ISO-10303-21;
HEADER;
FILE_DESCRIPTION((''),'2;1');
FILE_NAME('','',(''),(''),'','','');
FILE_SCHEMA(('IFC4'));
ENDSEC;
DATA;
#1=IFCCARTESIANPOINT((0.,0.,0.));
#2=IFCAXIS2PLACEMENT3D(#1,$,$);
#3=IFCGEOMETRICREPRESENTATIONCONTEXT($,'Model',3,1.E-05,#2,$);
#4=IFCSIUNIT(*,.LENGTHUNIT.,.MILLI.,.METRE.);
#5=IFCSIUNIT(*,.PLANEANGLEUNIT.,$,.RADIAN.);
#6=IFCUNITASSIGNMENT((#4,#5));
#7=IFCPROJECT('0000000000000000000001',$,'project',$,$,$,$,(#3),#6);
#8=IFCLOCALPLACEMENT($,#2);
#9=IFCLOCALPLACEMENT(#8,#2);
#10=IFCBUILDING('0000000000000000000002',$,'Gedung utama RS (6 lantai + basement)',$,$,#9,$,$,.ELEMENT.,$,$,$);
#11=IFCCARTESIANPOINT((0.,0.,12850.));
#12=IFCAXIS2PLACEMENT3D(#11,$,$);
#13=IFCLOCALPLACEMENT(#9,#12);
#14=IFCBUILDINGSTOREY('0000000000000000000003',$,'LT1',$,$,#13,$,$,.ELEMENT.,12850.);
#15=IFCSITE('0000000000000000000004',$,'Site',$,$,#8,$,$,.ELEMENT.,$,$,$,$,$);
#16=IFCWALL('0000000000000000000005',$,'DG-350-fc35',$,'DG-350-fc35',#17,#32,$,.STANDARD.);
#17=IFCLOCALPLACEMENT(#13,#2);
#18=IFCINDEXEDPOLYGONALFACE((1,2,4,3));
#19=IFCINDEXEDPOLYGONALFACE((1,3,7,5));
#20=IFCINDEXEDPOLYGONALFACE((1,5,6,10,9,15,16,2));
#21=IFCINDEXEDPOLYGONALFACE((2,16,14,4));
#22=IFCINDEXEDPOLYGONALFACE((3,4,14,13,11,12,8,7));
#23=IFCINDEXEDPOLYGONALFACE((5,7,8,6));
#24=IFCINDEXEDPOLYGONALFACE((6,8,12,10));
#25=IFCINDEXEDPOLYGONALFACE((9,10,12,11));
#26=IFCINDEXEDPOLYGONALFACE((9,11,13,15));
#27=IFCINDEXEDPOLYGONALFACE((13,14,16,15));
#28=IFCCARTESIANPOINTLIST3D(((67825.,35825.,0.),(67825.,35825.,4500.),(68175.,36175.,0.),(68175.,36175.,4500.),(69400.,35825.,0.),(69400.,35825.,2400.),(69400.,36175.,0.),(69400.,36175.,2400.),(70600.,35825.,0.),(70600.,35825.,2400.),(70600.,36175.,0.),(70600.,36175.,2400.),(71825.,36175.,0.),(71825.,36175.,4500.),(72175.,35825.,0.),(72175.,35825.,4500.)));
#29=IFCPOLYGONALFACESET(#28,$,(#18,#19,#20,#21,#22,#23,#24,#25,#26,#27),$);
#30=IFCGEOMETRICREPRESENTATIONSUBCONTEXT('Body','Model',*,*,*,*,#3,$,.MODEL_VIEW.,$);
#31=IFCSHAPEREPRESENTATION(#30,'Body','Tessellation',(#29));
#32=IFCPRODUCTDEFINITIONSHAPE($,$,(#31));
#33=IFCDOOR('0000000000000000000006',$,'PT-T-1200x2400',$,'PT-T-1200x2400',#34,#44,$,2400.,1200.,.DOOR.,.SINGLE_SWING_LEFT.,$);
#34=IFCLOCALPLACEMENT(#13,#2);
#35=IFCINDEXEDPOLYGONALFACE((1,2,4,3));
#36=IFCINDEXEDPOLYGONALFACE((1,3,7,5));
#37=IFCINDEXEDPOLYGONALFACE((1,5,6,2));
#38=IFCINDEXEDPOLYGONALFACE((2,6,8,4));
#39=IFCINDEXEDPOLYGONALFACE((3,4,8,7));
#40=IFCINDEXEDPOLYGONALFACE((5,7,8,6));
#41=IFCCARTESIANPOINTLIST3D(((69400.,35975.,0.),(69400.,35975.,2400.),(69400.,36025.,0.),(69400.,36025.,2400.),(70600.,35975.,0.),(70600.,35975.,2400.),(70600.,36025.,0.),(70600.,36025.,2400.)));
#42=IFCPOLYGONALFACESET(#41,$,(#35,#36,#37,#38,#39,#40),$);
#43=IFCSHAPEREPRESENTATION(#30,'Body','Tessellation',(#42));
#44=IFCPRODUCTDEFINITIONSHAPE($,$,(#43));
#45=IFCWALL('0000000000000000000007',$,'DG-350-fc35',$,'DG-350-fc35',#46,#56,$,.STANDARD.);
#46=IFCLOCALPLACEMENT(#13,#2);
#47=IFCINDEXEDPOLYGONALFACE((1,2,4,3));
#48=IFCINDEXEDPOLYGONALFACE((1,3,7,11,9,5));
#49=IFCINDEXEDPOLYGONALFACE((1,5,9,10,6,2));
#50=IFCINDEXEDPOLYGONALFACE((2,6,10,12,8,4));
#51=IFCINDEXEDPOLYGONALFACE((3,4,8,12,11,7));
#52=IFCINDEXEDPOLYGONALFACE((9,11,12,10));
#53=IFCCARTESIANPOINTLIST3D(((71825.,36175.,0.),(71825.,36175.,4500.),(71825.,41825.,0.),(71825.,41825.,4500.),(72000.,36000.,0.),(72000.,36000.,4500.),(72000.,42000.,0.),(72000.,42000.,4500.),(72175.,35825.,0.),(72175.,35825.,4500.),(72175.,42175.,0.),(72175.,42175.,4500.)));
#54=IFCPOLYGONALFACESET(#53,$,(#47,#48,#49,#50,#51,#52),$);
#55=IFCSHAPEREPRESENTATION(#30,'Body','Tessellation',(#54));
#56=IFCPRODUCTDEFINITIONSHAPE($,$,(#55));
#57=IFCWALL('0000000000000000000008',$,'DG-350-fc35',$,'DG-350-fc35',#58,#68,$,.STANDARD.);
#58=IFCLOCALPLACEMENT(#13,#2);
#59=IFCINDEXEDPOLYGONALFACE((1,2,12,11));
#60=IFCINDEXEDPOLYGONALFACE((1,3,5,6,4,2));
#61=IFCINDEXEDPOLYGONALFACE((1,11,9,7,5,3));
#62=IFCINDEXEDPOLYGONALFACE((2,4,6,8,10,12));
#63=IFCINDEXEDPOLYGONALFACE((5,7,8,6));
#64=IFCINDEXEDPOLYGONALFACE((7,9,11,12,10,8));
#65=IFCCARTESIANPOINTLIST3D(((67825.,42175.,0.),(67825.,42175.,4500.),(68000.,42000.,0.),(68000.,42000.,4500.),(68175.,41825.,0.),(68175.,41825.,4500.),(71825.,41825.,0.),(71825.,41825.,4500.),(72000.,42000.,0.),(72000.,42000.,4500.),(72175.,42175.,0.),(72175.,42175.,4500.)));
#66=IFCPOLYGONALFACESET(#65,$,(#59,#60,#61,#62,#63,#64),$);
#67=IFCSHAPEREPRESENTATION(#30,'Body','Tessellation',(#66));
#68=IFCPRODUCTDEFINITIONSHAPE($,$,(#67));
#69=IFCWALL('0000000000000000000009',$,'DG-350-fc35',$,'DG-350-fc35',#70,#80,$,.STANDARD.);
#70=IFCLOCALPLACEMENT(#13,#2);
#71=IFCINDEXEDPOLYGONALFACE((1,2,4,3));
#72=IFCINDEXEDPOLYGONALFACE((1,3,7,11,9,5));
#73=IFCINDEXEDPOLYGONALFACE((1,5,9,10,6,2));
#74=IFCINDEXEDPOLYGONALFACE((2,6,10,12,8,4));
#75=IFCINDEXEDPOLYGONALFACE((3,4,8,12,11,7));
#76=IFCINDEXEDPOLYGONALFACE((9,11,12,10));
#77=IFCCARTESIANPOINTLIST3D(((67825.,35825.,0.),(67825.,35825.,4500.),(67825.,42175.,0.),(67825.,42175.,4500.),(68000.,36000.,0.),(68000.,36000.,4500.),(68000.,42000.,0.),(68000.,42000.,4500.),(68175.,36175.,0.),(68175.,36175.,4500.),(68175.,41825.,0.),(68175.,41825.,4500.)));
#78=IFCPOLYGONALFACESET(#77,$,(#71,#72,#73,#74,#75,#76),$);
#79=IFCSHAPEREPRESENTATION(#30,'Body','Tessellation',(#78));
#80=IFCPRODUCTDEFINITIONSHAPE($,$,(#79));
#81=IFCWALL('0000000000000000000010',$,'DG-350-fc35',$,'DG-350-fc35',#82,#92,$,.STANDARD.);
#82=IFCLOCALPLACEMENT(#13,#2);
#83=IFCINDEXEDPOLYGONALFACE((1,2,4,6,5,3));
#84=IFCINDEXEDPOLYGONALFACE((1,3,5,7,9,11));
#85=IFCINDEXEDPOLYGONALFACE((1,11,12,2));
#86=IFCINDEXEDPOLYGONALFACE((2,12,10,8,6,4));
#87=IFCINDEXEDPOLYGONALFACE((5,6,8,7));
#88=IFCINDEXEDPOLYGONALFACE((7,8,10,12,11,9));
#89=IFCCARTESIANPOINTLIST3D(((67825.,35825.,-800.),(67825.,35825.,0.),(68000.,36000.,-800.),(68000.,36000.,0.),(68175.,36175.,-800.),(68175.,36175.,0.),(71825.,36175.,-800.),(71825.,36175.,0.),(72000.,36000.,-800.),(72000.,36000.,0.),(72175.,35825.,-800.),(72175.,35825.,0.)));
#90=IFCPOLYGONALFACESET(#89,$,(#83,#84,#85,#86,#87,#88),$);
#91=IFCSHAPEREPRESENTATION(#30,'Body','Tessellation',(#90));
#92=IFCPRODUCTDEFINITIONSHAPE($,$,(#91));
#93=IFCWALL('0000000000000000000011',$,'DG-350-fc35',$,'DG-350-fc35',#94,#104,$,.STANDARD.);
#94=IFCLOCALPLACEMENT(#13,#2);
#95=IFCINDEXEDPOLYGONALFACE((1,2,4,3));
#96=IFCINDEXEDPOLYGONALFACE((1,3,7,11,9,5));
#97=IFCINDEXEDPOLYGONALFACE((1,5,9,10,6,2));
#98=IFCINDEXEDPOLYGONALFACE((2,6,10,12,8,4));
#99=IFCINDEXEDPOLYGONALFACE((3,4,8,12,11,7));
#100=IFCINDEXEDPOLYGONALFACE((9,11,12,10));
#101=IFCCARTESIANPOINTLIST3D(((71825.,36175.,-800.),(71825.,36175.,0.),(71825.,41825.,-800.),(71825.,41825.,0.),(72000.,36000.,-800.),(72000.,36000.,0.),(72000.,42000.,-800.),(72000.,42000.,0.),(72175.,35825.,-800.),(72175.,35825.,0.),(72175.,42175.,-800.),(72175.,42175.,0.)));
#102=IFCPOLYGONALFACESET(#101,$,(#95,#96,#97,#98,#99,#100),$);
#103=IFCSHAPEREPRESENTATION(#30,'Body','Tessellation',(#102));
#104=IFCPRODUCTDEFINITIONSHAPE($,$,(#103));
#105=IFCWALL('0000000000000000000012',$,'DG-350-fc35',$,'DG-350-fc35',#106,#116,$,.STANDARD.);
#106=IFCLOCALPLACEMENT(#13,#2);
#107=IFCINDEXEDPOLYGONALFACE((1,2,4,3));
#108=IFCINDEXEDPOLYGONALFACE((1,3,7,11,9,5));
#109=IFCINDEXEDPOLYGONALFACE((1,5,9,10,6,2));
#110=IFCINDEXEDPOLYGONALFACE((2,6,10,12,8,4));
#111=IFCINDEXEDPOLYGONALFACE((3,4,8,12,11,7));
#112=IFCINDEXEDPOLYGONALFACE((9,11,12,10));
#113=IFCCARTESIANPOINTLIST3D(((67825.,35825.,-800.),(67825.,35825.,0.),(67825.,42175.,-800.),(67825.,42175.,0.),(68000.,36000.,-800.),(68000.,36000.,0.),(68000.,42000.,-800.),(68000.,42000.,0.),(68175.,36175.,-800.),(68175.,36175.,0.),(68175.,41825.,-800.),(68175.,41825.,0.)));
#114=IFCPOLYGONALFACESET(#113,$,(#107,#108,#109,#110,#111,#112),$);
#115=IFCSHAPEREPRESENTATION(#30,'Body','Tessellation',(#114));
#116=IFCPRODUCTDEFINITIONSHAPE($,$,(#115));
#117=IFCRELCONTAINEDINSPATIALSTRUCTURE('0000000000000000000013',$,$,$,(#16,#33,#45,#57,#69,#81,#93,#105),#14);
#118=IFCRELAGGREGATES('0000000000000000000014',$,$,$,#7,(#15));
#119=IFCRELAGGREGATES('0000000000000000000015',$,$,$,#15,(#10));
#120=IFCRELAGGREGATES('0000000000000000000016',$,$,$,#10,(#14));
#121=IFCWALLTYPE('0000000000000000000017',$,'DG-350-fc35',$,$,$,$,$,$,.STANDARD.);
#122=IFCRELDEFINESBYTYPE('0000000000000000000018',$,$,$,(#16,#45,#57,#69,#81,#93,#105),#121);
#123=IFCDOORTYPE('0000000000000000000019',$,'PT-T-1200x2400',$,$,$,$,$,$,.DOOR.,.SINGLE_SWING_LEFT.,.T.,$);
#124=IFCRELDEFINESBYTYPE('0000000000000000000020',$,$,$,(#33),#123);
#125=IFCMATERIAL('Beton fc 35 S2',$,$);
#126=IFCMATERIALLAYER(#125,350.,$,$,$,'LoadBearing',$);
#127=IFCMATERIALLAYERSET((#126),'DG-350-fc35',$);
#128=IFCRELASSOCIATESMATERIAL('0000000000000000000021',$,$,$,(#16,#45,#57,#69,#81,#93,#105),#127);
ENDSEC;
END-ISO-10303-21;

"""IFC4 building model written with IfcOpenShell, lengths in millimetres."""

from ifc_helpers import new_model, si_unit, frame, frame_2d, origin, place, context, subcontext, project, spatial, polyline, rectangle, outline, extrude, material, layer, layer_set, layer_usage, type_object, element, fill, save


model = new_model("IFC4")

# Units and contexts
model_context = context("Model", 3, precision=1e-05, world=origin())
body_context = subcontext(model_context, "Body", "Model", "MODEL_VIEW")
ifc_project = project(units=[si_unit("LENGTHUNIT", "METRE", prefix="MILLI"), si_unit("PLANEANGLEUNIT", "RADIAN")], contexts=[model_context])

# Site, building, storey
site_placement = place(None, origin())
site = spatial("IfcSite", under=ifc_project, at=site_placement, Name="Site", CompositionType="ELEMENT")
building_placement = place(site_placement, origin())
building = spatial("IfcBuilding", under=site, at=building_placement, Name="Gedung utama RS (6 lantai + basement)", CompositionType="ELEMENT")
storey_placement = place(building_placement, frame((0.0, 0.0, 12850.0)))
storey = spatial("IfcBuildingStorey", under=building, at=storey_placement, Name="LT1", CompositionType="ELEMENT", Elevation=12850.0)

# Shared definitions
ifc_material = material(Name="Beton fc 35 S2")

# Wall, opening, door
ifc_layer = layer(ifc_material, 350.0, Category="LoadBearing")
ifc_layer_set = layer_set([ifc_layer], Name="DG-350-fc35")
ifc_layer_usage = layer_usage(ifc_layer_set, "AXIS2", "NEGATIVE", 175.0)
wall_type = type_object("IfcWallType", Name="DG-350-fc35", PredefinedType="STANDARD")
wall_1_placement = place(storey_placement, frame((68000.0, 36000.0, 0.0), z_axis=(0.0, 0.0, 1.0), x_axis=(1.0, 0.0, 0.0)))
wall_1 = element("IfcWall", 1, at=wall_1_placement, inside=storey, type_object=wall_type, material=ifc_layer_usage, Name="DG-350-fc35", ObjectType="DG-350-fc35", PredefinedType="STANDARD", context=body_context, shape_type="SweptSolid", body=[
    extrude(outline(polyline([(-175.0, -175.0), (0.0, 0.0), (175.0, 175.0), (3825.0, 175.0), (4000.0, 0.0), (4175.0, -175.0), (-175.0, -175.0)])), origin(), (0.0, 0.0, 1.0), 4500.0),
])
opening_placement = place(wall_1_placement, frame((1400.0, 0.0, 0.0), z_axis=(0.0, 0.0, 1.0), x_axis=(1.0, 0.0, 0.0)))
opening = element("IfcOpeningElement", 2, at=opening_placement, cuts=wall_1, PredefinedType="OPENING", context=body_context, shape_type="SweptSolid", body=[
    extrude(rectangle(XDim=1200.0, YDim=370.0, at=frame_2d((600.0, 0.0))), origin(), (0.0, 0.0, 1.0), 2400.0),
])
door_type = type_object("IfcDoorType", Name="PT-T-1200x2400", OperationType="SINGLE_SWING_LEFT", ParameterTakesPrecedence=True, PredefinedType="DOOR")
door_placement = place(opening_placement, origin())
door = element("IfcDoor", 3, at=door_placement, inside=storey, type_object=door_type, Name="PT-T-1200x2400", ObjectType="PT-T-1200x2400", OperationType="SINGLE_SWING_LEFT", OverallHeight=2400.0, OverallWidth=1200.0, PredefinedType="DOOR", context=body_context, shape_type="SweptSolid", body=[
    extrude(rectangle(XDim=1200.0, YDim=50.0, at=frame_2d((600.0, 0.0))), origin(), (0.0, 0.0, 1.0), 2400.0),
])
fill(opening, door)

# Walls
wall_2_placement = place(storey_placement, frame((72000.0, 36000.0, 0.0), z_axis=(0.0, 0.0, 1.0), x_axis=(0.0, 1.0, 0.0)))
element("IfcWall", 4, at=wall_2_placement, inside=storey, type_object=wall_type, material=ifc_layer_usage, Name="DG-350-fc35", ObjectType="DG-350-fc35", PredefinedType="STANDARD", context=body_context, shape_type="SweptSolid", body=[
    extrude(outline(polyline([(-175.0, -175.0), (0.0, 0.0), (175.0, 175.0), (5825.0, 175.0), (6000.0, 0.0), (6175.0, -175.0), (-175.0, -175.0)])), origin(), (0.0, 0.0, 1.0), 4500.0),
])
wall_3_placement = place(storey_placement, frame((72000.0, 42000.0, 0.0), z_axis=(0.0, 0.0, 1.0), x_axis=(-1.0, 0.0, 0.0)))
element("IfcWall", 5, at=wall_3_placement, inside=storey, type_object=wall_type, material=ifc_layer_usage, Name="DG-350-fc35", ObjectType="DG-350-fc35", PredefinedType="STANDARD", context=body_context, shape_type="SweptSolid", body=[
    extrude(outline(polyline([(-175.0, -175.0), (0.0, 0.0), (175.0, 175.0), (3825.0, 175.0), (4000.0, 0.0), (4175.0, -175.0), (-175.0, -175.0)])), origin(), (0.0, 0.0, 1.0), 4500.0),
])
wall_4_placement = place(storey_placement, frame((68000.0, 42000.0, 0.0), z_axis=(0.0, 0.0, 1.0), x_axis=(0.0, -1.0, 0.0)))
element("IfcWall", 6, at=wall_4_placement, inside=storey, type_object=wall_type, material=ifc_layer_usage, Name="DG-350-fc35", ObjectType="DG-350-fc35", PredefinedType="STANDARD", context=body_context, shape_type="SweptSolid", body=[
    extrude(outline(polyline([(-175.0, -175.0), (0.0, 0.0), (175.0, 175.0), (5825.0, 175.0), (6000.0, 0.0), (6175.0, -175.0), (-175.0, -175.0)])), origin(), (0.0, 0.0, 1.0), 4500.0),
])
wall_5_placement = place(storey_placement, frame((68000.0, 36000.0, -800.0), z_axis=(0.0, 0.0, 1.0), x_axis=(1.0, 0.0, 0.0)))
element("IfcWall", 7, at=wall_5_placement, inside=storey, type_object=wall_type, material=ifc_layer_usage, Name="DG-350-fc35", ObjectType="DG-350-fc35", PredefinedType="STANDARD", context=body_context, shape_type="SweptSolid", body=[
    extrude(outline(polyline([(-175.0, -175.0), (0.0, 0.0), (175.0, 175.0), (3825.0, 175.0), (4000.0, 0.0), (4175.0, -175.0), (-175.0, -175.0)])), origin(), (0.0, 0.0, 1.0), 800.0),
])
for number, where, z_axis, x_axis, name in (
    (8, (72000.0, 36000.0, -800.0), (0.0, 0.0, 1.0), (0.0, 1.0, 0.0), "DG-350-fc35"),
    (9, (68000.0, 42000.0, -800.0), (0.0, 0.0, 1.0), (0.0, -1.0, 0.0), "DG-350-fc35"),
):
    element("IfcWall", number, at=place(storey_placement, frame(where, z_axis=z_axis, x_axis=x_axis)), inside=storey, type_object=wall_type, material=ifc_layer_usage, Name=name, ObjectType="DG-350-fc35", PredefinedType="STANDARD", context=body_context, shape_type="SweptSolid", body=[
        extrude(outline(polyline([(-175.0, -175.0), (0.0, 0.0), (175.0, 175.0), (5825.0, 175.0), (6000.0, 0.0), (6175.0, -175.0), (-175.0, -175.0)])), origin(), (0.0, 0.0, 1.0), 800.0),
    ])

save(model, "model.ifc")
